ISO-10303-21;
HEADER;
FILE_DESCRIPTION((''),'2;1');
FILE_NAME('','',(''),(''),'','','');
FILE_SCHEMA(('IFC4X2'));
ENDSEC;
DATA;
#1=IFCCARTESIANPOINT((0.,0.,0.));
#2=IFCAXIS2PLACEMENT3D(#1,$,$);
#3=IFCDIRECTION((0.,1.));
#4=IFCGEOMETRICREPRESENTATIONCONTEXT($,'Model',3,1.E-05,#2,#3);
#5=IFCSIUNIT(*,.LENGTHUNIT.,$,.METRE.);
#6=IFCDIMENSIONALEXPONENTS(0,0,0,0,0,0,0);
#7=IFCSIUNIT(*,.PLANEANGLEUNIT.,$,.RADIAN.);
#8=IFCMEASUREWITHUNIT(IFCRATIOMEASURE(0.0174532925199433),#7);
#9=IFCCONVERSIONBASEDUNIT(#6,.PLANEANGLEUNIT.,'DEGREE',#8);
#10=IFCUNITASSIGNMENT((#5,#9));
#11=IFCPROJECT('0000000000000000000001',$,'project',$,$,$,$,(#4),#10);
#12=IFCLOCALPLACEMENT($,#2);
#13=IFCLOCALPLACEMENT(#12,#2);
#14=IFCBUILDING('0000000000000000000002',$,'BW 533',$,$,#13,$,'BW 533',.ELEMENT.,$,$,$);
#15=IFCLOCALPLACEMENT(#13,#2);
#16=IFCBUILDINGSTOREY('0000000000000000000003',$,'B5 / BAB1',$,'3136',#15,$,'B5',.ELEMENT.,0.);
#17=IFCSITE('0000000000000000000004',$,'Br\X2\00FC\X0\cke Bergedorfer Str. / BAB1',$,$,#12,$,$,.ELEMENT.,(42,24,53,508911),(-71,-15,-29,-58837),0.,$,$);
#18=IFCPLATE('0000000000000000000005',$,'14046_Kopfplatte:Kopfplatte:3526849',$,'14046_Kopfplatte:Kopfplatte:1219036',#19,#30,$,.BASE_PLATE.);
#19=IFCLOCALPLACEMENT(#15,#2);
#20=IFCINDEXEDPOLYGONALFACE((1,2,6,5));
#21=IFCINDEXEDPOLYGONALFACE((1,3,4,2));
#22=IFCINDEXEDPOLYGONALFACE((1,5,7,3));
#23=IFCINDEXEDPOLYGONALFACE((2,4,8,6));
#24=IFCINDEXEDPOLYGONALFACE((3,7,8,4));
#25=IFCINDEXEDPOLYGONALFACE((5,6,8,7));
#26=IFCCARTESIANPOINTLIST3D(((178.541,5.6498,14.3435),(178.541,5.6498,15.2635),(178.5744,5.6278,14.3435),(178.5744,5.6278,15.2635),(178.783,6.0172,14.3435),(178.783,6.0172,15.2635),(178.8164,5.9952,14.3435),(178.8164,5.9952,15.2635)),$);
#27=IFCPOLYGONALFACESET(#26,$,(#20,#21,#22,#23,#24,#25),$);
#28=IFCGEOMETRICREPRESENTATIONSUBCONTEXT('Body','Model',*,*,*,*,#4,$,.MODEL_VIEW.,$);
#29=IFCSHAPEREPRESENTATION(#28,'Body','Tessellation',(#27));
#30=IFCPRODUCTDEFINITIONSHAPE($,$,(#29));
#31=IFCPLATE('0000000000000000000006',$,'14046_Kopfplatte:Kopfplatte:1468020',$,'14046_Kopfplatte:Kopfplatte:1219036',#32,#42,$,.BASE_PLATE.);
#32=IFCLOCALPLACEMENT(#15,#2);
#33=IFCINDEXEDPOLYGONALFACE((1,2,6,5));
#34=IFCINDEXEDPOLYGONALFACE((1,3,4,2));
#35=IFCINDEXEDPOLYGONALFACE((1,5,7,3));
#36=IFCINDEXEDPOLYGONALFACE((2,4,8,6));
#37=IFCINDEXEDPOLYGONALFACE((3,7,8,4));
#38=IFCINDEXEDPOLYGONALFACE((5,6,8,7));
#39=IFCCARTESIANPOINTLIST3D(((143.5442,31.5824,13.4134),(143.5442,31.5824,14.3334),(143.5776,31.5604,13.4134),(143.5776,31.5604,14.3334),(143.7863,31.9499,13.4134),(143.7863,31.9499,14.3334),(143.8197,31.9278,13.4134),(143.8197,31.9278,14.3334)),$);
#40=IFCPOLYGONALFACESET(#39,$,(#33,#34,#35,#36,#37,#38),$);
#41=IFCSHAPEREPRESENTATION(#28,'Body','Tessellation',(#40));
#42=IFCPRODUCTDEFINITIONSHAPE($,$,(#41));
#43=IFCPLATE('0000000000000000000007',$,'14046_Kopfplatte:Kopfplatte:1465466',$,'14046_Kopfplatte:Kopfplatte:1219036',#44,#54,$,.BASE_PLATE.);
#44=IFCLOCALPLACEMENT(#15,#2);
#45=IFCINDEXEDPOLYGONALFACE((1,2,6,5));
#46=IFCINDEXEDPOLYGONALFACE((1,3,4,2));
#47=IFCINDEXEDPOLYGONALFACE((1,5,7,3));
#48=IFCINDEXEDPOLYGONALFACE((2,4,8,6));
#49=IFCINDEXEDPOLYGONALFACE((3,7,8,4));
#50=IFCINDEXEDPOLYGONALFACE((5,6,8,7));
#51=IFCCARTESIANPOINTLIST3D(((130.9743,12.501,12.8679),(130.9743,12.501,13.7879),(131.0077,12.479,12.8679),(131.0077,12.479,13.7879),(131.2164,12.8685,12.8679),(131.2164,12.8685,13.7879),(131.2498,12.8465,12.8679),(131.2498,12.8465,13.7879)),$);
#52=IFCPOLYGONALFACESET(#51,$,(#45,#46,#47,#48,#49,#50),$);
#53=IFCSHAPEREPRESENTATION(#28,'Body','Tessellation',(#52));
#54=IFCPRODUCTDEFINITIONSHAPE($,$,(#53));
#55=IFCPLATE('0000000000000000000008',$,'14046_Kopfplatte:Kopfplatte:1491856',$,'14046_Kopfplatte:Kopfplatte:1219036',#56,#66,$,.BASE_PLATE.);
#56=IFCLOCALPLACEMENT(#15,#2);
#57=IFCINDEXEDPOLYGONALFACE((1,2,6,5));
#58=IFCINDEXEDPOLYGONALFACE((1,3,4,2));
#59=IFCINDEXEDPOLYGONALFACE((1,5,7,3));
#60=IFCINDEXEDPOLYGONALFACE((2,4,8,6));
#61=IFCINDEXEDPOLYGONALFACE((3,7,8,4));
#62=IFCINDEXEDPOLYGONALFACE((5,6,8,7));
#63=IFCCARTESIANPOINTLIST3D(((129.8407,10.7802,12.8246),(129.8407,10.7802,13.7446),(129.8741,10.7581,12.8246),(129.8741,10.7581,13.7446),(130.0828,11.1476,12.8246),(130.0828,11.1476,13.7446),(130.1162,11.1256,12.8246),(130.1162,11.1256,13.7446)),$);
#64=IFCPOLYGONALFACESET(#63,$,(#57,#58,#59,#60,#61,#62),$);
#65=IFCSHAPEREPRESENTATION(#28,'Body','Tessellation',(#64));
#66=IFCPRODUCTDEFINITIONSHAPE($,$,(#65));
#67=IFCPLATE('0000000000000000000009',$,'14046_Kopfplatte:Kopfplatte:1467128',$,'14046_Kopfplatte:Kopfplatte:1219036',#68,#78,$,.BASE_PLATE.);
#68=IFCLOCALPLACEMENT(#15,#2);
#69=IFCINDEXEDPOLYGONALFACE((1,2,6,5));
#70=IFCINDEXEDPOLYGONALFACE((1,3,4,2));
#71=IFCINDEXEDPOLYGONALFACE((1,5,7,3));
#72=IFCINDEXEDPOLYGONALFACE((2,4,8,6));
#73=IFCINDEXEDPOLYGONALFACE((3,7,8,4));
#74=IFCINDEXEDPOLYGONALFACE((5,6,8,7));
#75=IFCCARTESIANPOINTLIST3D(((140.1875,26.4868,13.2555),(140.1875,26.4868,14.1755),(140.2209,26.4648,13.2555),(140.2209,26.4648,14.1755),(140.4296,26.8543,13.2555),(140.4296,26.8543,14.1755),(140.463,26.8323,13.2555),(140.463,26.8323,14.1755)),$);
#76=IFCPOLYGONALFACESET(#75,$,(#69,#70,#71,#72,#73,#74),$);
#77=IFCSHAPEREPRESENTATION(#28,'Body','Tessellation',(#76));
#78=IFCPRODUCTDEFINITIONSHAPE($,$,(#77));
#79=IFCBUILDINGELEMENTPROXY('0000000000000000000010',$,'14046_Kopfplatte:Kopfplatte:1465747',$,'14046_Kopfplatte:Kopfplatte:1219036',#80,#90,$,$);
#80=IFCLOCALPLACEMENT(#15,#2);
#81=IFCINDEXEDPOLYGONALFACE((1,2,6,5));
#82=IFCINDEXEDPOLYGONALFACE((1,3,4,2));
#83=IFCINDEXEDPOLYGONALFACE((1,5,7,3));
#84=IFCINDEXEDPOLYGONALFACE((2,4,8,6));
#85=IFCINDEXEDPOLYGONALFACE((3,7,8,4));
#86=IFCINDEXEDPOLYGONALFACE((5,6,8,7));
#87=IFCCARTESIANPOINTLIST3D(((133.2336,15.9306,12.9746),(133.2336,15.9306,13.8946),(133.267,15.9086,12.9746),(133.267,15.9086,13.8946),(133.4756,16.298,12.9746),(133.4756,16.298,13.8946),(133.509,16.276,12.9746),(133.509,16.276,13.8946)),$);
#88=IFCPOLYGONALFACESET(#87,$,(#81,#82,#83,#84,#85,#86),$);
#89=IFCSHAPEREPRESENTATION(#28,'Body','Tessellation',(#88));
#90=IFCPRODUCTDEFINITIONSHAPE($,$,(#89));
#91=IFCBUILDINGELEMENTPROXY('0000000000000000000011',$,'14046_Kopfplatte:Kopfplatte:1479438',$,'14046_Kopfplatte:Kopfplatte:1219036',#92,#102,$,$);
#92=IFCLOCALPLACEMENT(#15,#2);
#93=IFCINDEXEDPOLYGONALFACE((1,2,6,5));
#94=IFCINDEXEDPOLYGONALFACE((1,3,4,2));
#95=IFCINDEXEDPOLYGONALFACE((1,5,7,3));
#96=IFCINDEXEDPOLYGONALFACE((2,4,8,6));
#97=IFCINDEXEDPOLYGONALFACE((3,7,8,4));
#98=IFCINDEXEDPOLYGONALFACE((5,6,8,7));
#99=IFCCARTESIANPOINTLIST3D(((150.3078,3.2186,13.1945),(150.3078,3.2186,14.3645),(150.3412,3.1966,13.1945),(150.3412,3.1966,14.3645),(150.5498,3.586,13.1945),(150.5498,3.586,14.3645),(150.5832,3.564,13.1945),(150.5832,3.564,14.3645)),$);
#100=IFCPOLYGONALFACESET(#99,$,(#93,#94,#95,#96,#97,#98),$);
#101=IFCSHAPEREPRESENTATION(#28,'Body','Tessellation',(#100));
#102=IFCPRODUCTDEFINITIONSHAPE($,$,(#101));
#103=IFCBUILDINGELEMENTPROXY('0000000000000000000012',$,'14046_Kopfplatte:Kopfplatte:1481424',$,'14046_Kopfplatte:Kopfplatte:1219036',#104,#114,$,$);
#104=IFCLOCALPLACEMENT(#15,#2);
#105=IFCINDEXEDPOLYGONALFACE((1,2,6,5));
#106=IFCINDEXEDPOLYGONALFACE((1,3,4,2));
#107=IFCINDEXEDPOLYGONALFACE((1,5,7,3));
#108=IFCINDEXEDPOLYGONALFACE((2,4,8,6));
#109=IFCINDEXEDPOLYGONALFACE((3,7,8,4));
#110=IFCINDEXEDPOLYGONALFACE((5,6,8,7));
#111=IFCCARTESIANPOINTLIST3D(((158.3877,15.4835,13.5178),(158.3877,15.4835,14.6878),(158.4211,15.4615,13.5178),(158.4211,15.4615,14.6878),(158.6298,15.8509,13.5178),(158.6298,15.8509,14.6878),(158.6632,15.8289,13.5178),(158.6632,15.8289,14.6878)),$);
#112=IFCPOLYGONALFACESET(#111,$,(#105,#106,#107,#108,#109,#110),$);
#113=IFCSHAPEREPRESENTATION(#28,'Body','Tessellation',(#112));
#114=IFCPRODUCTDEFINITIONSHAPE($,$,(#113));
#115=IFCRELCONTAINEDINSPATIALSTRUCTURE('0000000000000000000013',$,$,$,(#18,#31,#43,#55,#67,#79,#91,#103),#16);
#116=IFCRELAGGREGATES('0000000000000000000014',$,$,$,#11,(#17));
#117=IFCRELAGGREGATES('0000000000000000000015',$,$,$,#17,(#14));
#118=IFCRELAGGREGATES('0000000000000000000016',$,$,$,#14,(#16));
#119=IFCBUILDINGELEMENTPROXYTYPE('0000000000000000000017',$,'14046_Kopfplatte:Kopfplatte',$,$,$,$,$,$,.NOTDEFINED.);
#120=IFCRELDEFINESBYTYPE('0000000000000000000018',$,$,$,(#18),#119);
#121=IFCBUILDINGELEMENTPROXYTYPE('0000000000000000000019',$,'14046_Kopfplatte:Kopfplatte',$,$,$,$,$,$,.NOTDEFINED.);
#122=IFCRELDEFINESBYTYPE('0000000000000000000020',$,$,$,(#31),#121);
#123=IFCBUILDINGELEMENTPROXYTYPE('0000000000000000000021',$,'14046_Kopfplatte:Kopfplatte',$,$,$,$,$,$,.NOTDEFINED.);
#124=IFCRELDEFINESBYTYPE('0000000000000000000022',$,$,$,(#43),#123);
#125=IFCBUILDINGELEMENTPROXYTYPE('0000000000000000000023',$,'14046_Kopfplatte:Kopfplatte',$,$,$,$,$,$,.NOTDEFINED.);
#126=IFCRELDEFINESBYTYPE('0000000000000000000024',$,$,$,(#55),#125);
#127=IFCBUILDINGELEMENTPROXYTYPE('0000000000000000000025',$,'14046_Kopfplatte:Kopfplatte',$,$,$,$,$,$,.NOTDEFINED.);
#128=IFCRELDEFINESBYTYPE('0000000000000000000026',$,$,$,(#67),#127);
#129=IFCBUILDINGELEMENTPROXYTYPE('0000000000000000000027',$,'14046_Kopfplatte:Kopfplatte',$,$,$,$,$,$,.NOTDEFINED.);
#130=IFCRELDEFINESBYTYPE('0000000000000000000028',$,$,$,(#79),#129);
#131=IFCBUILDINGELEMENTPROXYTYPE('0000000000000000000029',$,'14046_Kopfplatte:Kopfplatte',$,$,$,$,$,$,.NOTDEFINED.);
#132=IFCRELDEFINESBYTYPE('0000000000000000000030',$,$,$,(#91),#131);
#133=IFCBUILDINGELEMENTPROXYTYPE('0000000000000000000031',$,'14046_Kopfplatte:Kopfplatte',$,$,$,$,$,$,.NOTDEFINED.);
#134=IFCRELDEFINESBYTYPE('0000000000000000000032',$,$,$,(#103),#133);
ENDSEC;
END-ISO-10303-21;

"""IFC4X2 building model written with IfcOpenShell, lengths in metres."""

from ifc_helpers import new_model, entity, si_unit, converted_unit, direction, frame, frame_2d, origin, origin_2d_with_axis, place, context, subcontext, project, spatial, rectangle, extrude, source, transform, mapped, type_object, type_shapes, element, save


model = new_model("IFC4X2")

# Units and contexts
model_context = context("Model", 3, precision=1e-05, world=origin(), true_north=direction((0.0, 1.0)))
body_context = subcontext(model_context, "Body", "Model", "MODEL_VIEW")
ifc_project = project(units=[si_unit("LENGTHUNIT", "METRE"), converted_unit("PLANEANGLEUNIT", "DEGREE", entity("IfcRatioMeasure", 0.0174532925199433), si_unit("PLANEANGLEUNIT", "RADIAN"), dimensions=[0, 0, 0, 0, 0, 0, 0])], contexts=[model_context])

# Site, building, storey
site_placement = place(None, origin())
site = spatial("IfcSite", under=ifc_project, at=site_placement, Name="Brücke Bergedorfer Str. / BAB1", CompositionType="ELEMENT", RefLatitude=(42, 24, 53, 508911), RefLongitude=(-71, -15, -29, -58837), RefElevation=0.0)
building_placement = place(site_placement, origin())
building = spatial("IfcBuilding", under=site, at=building_placement, Name="BW 533", LongName="BW 533", CompositionType="ELEMENT")
storey_placement = place(building_placement, origin())
storey = spatial("IfcBuildingStorey", under=building, at=storey_placement, Name="B5 / BAB1", ObjectType="3136", LongName="B5", CompositionType="ELEMENT", Elevation=0.0)

# Plates
building_element_proxy_type_1 = type_object("IfcBuildingElementProxyType", Name="14046_Kopfplatte:Kopfplatte", PredefinedType="NOTDEFINED")
shared_shape_1 = source(origin(), body_context, "Body", "SweptSolid", [
    extrude(rectangle(XDim=0.04, YDim=0.44, at=frame_2d((0.0, 0.0), x_axis=(1.0, 0.0))), frame((178.6787, 5.8225, 14.3435), z_axis=(0.0, 0.0, 1.0), x_axis=(0.835088, -0.550116, 0.0)), (0.0, 0.0, 1.0), 0.92),
])
type_shapes(building_element_proxy_type_1, [shared_shape_1])
plate_1_placement = place(storey_placement, origin())
element("IfcPlate", 1, at=plate_1_placement, inside=storey, type_object=building_element_proxy_type_1, Name="14046_Kopfplatte:Kopfplatte:3526849", ObjectType="14046_Kopfplatte:Kopfplatte:1219036", PredefinedType="BASE_PLATE", context=body_context, shape_type="MappedRepresentation", body=[
    mapped(shared_shape_1, transform((0.0, 0.0, 0.0), scale=1.0)),
])
building_element_proxy_type_2 = type_object("IfcBuildingElementProxyType", Name="14046_Kopfplatte:Kopfplatte", PredefinedType="NOTDEFINED")
shared_shape_2 = source(origin(), body_context, "Body", "SweptSolid", [
    extrude(rectangle(XDim=0.04, YDim=0.44, at=frame_2d((0.0, 0.0), x_axis=(1.0, 0.0))), frame((143.682, 31.7551, 13.4134), z_axis=(0.0, 0.0, 1.0), x_axis=(-0.835088, 0.550116, 0.0)), (0.0, 0.0, 1.0), 0.92),
])
type_shapes(building_element_proxy_type_2, [shared_shape_2])
plate_2_placement = place(storey_placement, origin())
element("IfcPlate", 2, at=plate_2_placement, inside=storey, type_object=building_element_proxy_type_2, Name="14046_Kopfplatte:Kopfplatte:1468020", ObjectType="14046_Kopfplatte:Kopfplatte:1219036", PredefinedType="BASE_PLATE", context=body_context, shape_type="MappedRepresentation", body=[
    mapped(shared_shape_2, transform((0.0, 0.0, 0.0), scale=1.0)),
])
building_element_proxy_type_3 = type_object("IfcBuildingElementProxyType", Name="14046_Kopfplatte:Kopfplatte", PredefinedType="NOTDEFINED")
shared_shape_3 = source(origin(), body_context, "Body", "SweptSolid", [
    extrude(rectangle(XDim=0.04, YDim=0.44, at=frame_2d((0.0, 0.0), x_axis=(1.0, 0.0))), frame((131.1121, 12.6738, 12.8679), z_axis=(0.0, 0.0, 1.0), x_axis=(-0.835088, 0.550116, 0.0)), (0.0, 0.0, 1.0), 0.92),
])
type_shapes(building_element_proxy_type_3, [shared_shape_3])
plate_3_placement = place(storey_placement, origin())
element("IfcPlate", 3, at=plate_3_placement, inside=storey, type_object=building_element_proxy_type_3, Name="14046_Kopfplatte:Kopfplatte:1465466", ObjectType="14046_Kopfplatte:Kopfplatte:1219036", PredefinedType="BASE_PLATE", context=body_context, shape_type="MappedRepresentation", body=[
    mapped(shared_shape_3, transform((0.0, 0.0, 0.0), scale=1.0)),
])
building_element_proxy_type_4 = type_object("IfcBuildingElementProxyType", Name="14046_Kopfplatte:Kopfplatte", PredefinedType="NOTDEFINED")
shared_shape_4 = source(origin(), body_context, "Body", "SweptSolid", [
    extrude(rectangle(XDim=0.04, YDim=0.44, at=frame_2d((0.0, 0.0), x_axis=(1.0, 0.0))), frame((129.9784, 10.9529, 12.8246), z_axis=(0.0, 0.0, 1.0), x_axis=(-0.835088, 0.550116, 0.0)), (0.0, 0.0, 1.0), 0.92),
])
type_shapes(building_element_proxy_type_4, [shared_shape_4])
plate_4_placement = place(storey_placement, origin())
element("IfcPlate", 4, at=plate_4_placement, inside=storey, type_object=building_element_proxy_type_4, Name="14046_Kopfplatte:Kopfplatte:1491856", ObjectType="14046_Kopfplatte:Kopfplatte:1219036", PredefinedType="BASE_PLATE", context=body_context, shape_type="MappedRepresentation", body=[
    mapped(shared_shape_4, transform((0.0, 0.0, 0.0), scale=1.0)),
])
building_element_proxy_type_5 = type_object("IfcBuildingElementProxyType", Name="14046_Kopfplatte:Kopfplatte", PredefinedType="NOTDEFINED")
shared_shape_5 = source(origin(), body_context, "Body", "SweptSolid", [
    extrude(rectangle(XDim=0.04, YDim=0.44, at=frame_2d((0.0, 0.0), x_axis=(1.0, 0.0))), frame((140.3252, 26.6595, 13.2555), z_axis=(0.0, 0.0, 1.0), x_axis=(-0.835088, 0.550116, 0.0)), (0.0, 0.0, 1.0), 0.92),
])
type_shapes(building_element_proxy_type_5, [shared_shape_5])
plate_5_placement = place(storey_placement, origin())
element("IfcPlate", 5, at=plate_5_placement, inside=storey, type_object=building_element_proxy_type_5, Name="14046_Kopfplatte:Kopfplatte:1467128", ObjectType="14046_Kopfplatte:Kopfplatte:1219036", PredefinedType="BASE_PLATE", context=body_context, shape_type="MappedRepresentation", body=[
    mapped(shared_shape_5, transform((0.0, 0.0, 0.0), scale=1.0)),
])

# Building element proxies
building_element_proxy_type_6 = type_object("IfcBuildingElementProxyType", Name="14046_Kopfplatte:Kopfplatte", PredefinedType="NOTDEFINED")
shared_shape_6 = source(origin(), body_context, "Body", "SweptSolid", [
    extrude(rectangle(XDim=0.04, YDim=0.44, at=frame_2d((0.0, 0.0), x_axis=(1.0, 0.0))), frame((133.3713, 16.1033, 12.9746), z_axis=(0.0, 0.0, 1.0), x_axis=(-0.835088, 0.550116, 0.0)), (0.0, 0.0, 1.0), 0.92),
])
type_shapes(building_element_proxy_type_6, [shared_shape_6])
proxy_1_placement = place(storey_placement, origin())
element("IfcBuildingElementProxy", 6, at=proxy_1_placement, inside=storey, type_object=building_element_proxy_type_6, Name="14046_Kopfplatte:Kopfplatte:1465747", ObjectType="14046_Kopfplatte:Kopfplatte:1219036", context=body_context, shape_type="MappedRepresentation", body=[
    mapped(shared_shape_6, transform((0.0, 0.0, 0.0), scale=1.0)),
])
building_element_proxy_type_7 = type_object("IfcBuildingElementProxyType", Name="14046_Kopfplatte:Kopfplatte", PredefinedType="NOTDEFINED")
shared_shape_7 = source(origin(), body_context, "Body", "SweptSolid", [
    extrude(rectangle(XDim=0.04, YDim=0.44, at=origin_2d_with_axis()), frame((150.4455, 3.3913, 13.1945), z_axis=(0.0, 0.0, 1.0), x_axis=(0.835088, -0.550116, 0.0)), (0.0, 0.0, 1.0), 1.17),
])
type_shapes(building_element_proxy_type_7, [shared_shape_7])
proxy_2_placement = place(storey_placement, origin())
element("IfcBuildingElementProxy", 7, at=proxy_2_placement, inside=storey, type_object=building_element_proxy_type_7, Name="14046_Kopfplatte:Kopfplatte:1479438", ObjectType="14046_Kopfplatte:Kopfplatte:1219036", context=body_context, shape_type="MappedRepresentation", body=[
    mapped(shared_shape_7, transform((0.0, 0.0, 0.0), scale=1.0)),
])
building_element_proxy_type_8 = type_object("IfcBuildingElementProxyType", Name="14046_Kopfplatte:Kopfplatte", PredefinedType="NOTDEFINED")
shared_shape_8 = source(origin(), body_context, "Body", "SweptSolid", [
    extrude(rectangle(XDim=0.04, YDim=0.44, at=frame_2d((0.0, 0.0), x_axis=(1.0, 0.0))), frame((158.5254, 15.6562, 13.5178), z_axis=(0.0, 0.0, 1.0), x_axis=(0.835088, -0.550116, 0.0)), (0.0, 0.0, 1.0), 1.17),
])
type_shapes(building_element_proxy_type_8, [shared_shape_8])
proxy_3_placement = place(storey_placement, origin())
element("IfcBuildingElementProxy", 8, at=proxy_3_placement, inside=storey, type_object=building_element_proxy_type_8, Name="14046_Kopfplatte:Kopfplatte:1481424", ObjectType="14046_Kopfplatte:Kopfplatte:1219036", context=body_context, shape_type="MappedRepresentation", body=[
    mapped(shared_shape_8, transform((0.0, 0.0, 0.0), scale=1.0)),
])

save(model, "model.ifc")
